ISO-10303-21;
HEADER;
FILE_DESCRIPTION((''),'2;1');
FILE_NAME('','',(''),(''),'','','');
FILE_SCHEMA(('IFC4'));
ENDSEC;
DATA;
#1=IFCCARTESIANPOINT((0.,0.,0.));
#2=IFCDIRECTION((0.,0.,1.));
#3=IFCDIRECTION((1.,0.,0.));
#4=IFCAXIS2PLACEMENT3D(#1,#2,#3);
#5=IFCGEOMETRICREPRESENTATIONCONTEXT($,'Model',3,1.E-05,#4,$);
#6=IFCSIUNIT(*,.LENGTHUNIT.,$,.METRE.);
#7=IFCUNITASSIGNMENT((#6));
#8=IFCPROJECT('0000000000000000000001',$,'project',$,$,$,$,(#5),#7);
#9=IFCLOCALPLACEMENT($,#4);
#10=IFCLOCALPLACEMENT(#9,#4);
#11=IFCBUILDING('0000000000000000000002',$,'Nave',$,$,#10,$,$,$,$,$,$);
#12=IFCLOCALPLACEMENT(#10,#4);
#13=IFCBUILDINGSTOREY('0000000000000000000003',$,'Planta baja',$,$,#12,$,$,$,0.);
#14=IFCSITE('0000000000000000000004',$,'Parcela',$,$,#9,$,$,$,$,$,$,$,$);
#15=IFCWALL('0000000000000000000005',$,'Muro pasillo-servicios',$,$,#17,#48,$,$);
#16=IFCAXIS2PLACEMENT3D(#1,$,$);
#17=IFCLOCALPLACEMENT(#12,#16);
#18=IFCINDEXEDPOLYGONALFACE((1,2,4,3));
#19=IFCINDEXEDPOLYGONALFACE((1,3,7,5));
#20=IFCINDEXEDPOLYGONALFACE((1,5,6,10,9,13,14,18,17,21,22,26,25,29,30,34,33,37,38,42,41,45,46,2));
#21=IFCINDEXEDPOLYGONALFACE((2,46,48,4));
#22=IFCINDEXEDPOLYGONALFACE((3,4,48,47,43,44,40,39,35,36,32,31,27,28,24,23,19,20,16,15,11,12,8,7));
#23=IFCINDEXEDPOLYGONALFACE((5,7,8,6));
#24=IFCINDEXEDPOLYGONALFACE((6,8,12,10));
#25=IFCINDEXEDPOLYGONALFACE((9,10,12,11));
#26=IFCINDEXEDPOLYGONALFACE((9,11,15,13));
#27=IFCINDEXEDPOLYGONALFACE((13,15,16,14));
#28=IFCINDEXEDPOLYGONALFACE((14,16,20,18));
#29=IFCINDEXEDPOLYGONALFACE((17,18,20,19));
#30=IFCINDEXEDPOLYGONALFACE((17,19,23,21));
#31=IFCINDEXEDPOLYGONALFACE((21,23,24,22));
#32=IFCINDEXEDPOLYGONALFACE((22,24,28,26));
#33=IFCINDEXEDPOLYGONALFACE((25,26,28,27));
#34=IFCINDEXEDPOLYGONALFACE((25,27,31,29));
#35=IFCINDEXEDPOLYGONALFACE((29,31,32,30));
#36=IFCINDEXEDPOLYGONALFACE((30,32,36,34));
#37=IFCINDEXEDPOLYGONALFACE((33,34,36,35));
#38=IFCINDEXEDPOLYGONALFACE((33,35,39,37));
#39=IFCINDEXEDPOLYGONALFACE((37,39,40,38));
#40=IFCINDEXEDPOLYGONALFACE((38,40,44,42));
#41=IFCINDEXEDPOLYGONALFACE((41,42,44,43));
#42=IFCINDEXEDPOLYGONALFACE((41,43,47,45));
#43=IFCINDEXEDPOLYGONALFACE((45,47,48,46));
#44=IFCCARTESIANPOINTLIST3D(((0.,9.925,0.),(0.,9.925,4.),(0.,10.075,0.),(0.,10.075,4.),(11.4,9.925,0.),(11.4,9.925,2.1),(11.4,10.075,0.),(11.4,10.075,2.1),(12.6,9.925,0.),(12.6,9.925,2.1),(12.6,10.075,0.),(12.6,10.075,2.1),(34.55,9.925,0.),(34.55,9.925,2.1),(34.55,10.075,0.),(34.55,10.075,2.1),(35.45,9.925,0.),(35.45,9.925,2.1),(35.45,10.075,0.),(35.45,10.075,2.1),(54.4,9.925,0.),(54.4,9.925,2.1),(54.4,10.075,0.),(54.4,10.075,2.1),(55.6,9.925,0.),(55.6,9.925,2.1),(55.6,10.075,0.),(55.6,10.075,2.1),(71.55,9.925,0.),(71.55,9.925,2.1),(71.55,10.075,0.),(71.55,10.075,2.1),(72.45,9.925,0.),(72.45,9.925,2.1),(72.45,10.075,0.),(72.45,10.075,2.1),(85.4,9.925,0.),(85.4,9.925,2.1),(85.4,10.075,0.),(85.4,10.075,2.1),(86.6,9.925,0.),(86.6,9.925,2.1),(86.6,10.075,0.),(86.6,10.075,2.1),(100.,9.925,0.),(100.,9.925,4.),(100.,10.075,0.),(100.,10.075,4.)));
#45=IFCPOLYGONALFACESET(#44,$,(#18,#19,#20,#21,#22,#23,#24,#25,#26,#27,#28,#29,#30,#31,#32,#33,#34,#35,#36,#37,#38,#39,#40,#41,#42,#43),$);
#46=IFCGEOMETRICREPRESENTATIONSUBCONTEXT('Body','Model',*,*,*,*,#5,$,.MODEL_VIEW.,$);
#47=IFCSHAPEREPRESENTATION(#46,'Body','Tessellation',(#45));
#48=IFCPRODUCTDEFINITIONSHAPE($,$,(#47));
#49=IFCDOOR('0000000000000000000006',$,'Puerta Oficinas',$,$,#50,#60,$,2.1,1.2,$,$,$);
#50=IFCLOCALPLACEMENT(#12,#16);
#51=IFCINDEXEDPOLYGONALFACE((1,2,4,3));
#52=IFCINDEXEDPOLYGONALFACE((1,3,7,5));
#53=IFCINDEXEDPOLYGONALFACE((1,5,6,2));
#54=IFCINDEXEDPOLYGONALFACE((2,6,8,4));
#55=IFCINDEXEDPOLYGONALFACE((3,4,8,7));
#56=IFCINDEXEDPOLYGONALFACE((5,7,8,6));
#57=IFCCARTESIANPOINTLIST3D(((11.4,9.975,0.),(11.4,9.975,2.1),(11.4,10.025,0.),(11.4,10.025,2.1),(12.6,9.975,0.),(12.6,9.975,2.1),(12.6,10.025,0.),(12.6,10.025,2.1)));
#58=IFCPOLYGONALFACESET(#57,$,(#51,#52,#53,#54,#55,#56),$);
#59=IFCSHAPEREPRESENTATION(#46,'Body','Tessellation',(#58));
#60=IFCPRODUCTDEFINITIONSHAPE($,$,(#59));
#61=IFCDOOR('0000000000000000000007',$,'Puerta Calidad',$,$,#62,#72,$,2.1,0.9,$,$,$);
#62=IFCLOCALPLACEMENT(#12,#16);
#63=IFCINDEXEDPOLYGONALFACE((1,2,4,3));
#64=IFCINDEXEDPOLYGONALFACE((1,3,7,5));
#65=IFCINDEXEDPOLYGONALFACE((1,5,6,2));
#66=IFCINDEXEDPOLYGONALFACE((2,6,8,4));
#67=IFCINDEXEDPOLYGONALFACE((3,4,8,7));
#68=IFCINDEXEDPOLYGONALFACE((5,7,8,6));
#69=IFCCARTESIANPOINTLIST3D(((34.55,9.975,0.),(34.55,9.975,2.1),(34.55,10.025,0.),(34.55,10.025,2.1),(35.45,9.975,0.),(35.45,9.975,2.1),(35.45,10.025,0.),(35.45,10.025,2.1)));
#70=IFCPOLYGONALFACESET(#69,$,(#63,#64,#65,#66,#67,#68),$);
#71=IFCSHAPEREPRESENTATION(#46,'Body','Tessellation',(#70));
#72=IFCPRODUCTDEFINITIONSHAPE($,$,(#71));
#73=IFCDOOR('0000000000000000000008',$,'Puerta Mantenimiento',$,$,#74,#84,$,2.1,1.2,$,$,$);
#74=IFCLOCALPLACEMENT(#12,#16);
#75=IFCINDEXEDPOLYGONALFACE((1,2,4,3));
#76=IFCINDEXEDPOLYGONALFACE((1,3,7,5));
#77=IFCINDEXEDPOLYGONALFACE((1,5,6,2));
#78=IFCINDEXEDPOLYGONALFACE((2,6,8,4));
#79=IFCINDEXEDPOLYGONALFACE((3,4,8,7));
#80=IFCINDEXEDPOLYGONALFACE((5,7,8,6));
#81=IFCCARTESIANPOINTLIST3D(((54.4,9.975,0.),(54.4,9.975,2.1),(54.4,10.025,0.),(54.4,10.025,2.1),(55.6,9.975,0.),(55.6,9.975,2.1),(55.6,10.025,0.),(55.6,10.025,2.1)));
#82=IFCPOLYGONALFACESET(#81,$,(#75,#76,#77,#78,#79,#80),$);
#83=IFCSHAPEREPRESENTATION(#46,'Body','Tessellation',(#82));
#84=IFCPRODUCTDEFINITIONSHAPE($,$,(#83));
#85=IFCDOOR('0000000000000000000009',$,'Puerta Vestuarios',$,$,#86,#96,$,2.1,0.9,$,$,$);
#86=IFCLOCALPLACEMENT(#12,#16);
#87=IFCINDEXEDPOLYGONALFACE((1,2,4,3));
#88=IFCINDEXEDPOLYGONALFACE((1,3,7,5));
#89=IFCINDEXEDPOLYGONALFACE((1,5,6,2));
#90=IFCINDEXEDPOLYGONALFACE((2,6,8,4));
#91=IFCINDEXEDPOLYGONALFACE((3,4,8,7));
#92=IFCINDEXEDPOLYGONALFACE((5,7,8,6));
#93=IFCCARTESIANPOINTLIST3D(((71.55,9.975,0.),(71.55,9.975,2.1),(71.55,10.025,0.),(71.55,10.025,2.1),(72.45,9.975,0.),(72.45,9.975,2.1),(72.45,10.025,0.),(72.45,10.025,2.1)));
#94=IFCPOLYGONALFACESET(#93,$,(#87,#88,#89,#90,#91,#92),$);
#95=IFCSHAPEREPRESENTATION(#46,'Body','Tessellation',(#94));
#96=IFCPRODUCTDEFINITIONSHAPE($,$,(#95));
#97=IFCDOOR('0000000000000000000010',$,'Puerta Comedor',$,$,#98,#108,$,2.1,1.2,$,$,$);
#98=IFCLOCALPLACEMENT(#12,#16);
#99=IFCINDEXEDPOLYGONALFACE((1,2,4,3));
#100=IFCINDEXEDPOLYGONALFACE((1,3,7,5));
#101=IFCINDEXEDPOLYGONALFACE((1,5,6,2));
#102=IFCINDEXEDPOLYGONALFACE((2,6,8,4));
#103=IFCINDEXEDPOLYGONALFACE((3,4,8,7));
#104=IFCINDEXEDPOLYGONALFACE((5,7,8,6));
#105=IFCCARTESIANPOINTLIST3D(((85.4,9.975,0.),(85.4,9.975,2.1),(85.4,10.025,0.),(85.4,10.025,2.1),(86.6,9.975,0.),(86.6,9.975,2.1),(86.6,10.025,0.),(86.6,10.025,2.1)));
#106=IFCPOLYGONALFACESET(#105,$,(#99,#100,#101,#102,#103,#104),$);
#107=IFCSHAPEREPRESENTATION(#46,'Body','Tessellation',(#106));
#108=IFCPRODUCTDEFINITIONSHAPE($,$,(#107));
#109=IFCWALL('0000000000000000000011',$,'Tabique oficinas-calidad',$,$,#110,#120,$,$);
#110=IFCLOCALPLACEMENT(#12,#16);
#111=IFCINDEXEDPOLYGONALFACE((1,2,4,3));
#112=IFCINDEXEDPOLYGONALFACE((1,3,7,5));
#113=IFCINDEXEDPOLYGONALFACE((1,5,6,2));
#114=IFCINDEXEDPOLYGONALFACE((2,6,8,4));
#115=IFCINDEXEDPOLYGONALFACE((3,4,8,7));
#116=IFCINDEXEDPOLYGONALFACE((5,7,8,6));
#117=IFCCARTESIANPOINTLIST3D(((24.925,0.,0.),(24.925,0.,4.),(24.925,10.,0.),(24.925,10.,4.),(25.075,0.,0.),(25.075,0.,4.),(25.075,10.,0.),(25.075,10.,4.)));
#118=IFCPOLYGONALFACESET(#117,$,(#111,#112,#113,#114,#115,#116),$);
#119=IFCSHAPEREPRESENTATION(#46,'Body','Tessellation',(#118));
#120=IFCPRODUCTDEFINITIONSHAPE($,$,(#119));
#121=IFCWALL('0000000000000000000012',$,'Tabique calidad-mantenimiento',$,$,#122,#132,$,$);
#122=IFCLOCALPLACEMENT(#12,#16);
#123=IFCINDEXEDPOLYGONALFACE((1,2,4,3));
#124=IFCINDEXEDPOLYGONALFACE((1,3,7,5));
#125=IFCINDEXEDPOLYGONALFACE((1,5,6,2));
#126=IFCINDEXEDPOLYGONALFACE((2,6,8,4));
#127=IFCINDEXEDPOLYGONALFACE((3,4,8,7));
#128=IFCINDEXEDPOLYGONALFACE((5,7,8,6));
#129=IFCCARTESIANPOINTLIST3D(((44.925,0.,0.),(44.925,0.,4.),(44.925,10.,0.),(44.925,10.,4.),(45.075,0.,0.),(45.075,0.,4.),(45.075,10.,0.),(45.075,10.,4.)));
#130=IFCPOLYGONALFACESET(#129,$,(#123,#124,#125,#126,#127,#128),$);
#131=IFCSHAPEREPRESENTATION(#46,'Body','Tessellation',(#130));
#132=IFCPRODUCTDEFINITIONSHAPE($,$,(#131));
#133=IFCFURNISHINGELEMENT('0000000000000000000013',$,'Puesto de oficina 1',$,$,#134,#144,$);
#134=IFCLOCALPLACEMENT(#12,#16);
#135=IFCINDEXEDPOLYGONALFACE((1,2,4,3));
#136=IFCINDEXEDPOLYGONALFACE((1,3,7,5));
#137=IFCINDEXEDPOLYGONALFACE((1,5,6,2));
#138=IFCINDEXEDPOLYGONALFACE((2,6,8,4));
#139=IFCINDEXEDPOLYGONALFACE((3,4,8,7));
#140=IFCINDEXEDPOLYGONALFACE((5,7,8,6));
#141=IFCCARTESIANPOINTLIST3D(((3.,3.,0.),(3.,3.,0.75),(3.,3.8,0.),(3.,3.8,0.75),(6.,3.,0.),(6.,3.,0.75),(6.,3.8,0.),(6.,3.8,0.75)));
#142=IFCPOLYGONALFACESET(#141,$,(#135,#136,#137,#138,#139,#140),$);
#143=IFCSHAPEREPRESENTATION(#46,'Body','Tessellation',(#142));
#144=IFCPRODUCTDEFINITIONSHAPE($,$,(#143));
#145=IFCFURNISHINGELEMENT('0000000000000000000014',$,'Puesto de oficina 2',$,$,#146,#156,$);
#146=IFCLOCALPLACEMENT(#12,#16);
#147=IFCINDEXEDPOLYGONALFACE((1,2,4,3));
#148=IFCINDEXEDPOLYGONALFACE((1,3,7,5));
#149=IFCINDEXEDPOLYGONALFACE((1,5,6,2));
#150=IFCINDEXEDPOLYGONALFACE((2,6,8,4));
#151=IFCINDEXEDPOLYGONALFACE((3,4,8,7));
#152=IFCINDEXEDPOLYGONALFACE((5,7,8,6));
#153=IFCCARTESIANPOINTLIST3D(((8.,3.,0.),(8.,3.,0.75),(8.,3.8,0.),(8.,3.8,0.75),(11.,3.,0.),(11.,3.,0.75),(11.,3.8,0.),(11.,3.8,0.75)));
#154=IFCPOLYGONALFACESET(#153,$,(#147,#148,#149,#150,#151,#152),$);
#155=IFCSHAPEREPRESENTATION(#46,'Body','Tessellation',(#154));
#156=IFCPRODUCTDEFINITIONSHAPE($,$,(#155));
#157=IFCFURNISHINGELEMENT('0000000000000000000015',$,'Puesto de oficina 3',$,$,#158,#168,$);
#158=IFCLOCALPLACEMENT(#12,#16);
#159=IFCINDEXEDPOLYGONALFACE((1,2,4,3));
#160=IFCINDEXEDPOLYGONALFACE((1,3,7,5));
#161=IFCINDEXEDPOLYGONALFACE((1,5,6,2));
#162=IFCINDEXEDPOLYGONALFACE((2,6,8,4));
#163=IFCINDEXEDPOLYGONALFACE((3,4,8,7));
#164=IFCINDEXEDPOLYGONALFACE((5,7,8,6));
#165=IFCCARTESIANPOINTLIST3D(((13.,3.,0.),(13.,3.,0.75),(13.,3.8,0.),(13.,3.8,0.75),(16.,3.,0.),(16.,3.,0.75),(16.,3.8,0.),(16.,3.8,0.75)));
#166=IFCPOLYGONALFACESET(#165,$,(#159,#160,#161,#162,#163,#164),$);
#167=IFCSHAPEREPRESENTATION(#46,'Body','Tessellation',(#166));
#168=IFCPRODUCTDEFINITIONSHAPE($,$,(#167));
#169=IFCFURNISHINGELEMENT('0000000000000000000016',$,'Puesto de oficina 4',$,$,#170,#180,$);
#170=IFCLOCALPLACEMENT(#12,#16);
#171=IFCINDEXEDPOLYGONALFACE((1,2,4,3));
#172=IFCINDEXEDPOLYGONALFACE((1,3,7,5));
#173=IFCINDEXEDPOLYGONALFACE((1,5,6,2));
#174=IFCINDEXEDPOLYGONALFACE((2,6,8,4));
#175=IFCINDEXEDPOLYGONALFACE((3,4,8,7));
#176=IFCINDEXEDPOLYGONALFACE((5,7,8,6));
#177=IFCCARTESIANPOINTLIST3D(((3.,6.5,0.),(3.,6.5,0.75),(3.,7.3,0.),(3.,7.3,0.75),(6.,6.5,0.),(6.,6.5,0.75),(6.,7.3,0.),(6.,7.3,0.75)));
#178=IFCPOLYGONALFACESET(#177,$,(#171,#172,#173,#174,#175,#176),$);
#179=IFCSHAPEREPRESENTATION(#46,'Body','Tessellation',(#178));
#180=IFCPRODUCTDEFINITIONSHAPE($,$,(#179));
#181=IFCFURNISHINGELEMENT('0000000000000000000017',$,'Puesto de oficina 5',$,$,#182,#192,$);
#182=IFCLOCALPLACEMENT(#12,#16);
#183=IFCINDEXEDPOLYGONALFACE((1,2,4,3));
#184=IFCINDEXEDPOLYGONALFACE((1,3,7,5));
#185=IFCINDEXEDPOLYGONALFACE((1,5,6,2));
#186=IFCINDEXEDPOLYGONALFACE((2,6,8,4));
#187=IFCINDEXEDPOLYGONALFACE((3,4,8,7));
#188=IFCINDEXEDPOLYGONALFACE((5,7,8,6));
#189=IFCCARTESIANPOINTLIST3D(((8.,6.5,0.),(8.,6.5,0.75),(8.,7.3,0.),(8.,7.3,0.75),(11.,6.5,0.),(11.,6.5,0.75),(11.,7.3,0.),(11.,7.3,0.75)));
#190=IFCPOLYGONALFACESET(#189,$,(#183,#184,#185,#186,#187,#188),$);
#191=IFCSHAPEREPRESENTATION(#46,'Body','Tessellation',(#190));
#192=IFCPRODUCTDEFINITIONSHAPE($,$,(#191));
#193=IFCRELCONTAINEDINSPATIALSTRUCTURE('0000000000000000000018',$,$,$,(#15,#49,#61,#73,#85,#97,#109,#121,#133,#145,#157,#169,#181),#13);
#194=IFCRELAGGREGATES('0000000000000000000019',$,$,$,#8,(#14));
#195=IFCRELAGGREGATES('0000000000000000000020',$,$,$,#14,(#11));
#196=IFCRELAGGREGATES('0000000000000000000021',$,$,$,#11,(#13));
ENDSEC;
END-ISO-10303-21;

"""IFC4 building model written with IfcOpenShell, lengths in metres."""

from ifc_helpers import new_model, si_unit, frame, origin_with_axes, place, context, subcontext, project, spatial, indexed_curve, outline, extrude, element, fill, save


model = new_model("IFC4")

# Units and contexts
model_context = context("Model", 3, precision=1e-05, world=origin_with_axes())
body_context = subcontext(model_context, "Body", "Model", "MODEL_VIEW")
ifc_project = project(units=[si_unit("LENGTHUNIT", "METRE")], contexts=[model_context])

# Site, building, storey
site_placement = place(None, origin_with_axes())
site = spatial("IfcSite", under=ifc_project, at=site_placement, Name="Parcela")
building_placement = place(site_placement, origin_with_axes())
building = spatial("IfcBuilding", under=site, at=building_placement, Name="Nave")
storey_placement = place(building_placement, origin_with_axes())
storey = spatial("IfcBuildingStorey", under=building, at=storey_placement, Name="Planta baja", Elevation=0.0)

# Wall, openings, doors
wall_1_placement = place(storey_placement, frame((0.0, 9.925, 0.0), z_axis=(0.0, 0.0, 1.0), x_axis=(1.0, 0.0, 0.0)))
wall_1 = element("IfcWall", 1, at=wall_1_placement, inside=storey, Name="Muro pasillo-servicios", context=body_context, shape_type="SweptSolid", body=[
    extrude(outline(indexed_curve([(0.0, 0.0), (0.0, 0.15), (100.0, 0.15), (100.0, 0.0), (0.0, 0.0)], self_intersect=False)), origin_with_axes(), (0.0, 0.0, 1.0), 4.0),
])
opening_1_placement = place(wall_1_placement, frame((11.4, -0.05, 0.0), z_axis=(0.0, 0.0, 1.0), x_axis=(1.0, 0.0, 0.0)))
opening_1 = element("IfcOpeningElement", 2, at=opening_1_placement, cuts=wall_1, context=body_context, shape_type="SweptSolid", body=[
    extrude(outline(indexed_curve([(0.0, 0.0), (0.0, 0.25), (1.2, 0.25), (1.2, 0.0), (0.0, 0.0)], self_intersect=False)), origin_with_axes(), (0.0, 0.0, 1.0), 2.1),
])
opening_2_placement = place(wall_1_placement, frame((34.55, -0.05, 0.0), z_axis=(0.0, 0.0, 1.0), x_axis=(1.0, 0.0, 0.0)))
opening_2 = element("IfcOpeningElement", 3, at=opening_2_placement, cuts=wall_1, context=body_context, shape_type="SweptSolid", body=[
    extrude(outline(indexed_curve([(0.0, 0.0), (0.0, 0.25), (0.9, 0.25), (0.9, 0.0), (0.0, 0.0)], self_intersect=False)), origin_with_axes(), (0.0, 0.0, 1.0), 2.1),
])
opening_3_placement = place(wall_1_placement, frame((54.4, -0.05, 0.0), z_axis=(0.0, 0.0, 1.0), x_axis=(1.0, 0.0, 0.0)))
opening_3 = element("IfcOpeningElement", 4, at=opening_3_placement, cuts=wall_1, context=body_context, shape_type="SweptSolid", body=[
    extrude(outline(indexed_curve([(0.0, 0.0), (0.0, 0.25), (1.2, 0.25), (1.2, 0.0), (0.0, 0.0)], self_intersect=False)), origin_with_axes(), (0.0, 0.0, 1.0), 2.1),
])
opening_4_placement = place(wall_1_placement, frame((71.55, -0.05, 0.0), z_axis=(0.0, 0.0, 1.0), x_axis=(1.0, 0.0, 0.0)))
opening_4 = element("IfcOpeningElement", 5, at=opening_4_placement, cuts=wall_1, context=body_context, shape_type="SweptSolid", body=[
    extrude(outline(indexed_curve([(0.0, 0.0), (0.0, 0.25), (0.9, 0.25), (0.9, 0.0), (0.0, 0.0)], self_intersect=False)), origin_with_axes(), (0.0, 0.0, 1.0), 2.1),
])
opening_5_placement = place(wall_1_placement, frame((85.4, -0.05, 0.0), z_axis=(0.0, 0.0, 1.0), x_axis=(1.0, 0.0, 0.0)))
opening_5 = element("IfcOpeningElement", 6, at=opening_5_placement, cuts=wall_1, context=body_context, shape_type="SweptSolid", body=[
    extrude(outline(indexed_curve([(0.0, 0.0), (0.0, 0.25), (1.2, 0.25), (1.2, 0.0), (0.0, 0.0)], self_intersect=False)), origin_with_axes(), (0.0, 0.0, 1.0), 2.1),
])
door_1_placement = place(opening_1_placement, frame((0.0, 0.1, 0.0), z_axis=(0.0, 0.0, 1.0), x_axis=(1.0, 0.0, 0.0)))
door_1 = element("IfcDoor", 7, at=door_1_placement, inside=storey, Name="Puerta Oficinas", OverallHeight=2.1, OverallWidth=1.2, context=body_context, shape_type="SweptSolid", body=[
    extrude(outline(indexed_curve([(0.0, 0.0), (0.0, 0.05), (1.2, 0.05), (1.2, 0.0), (0.0, 0.0)], self_intersect=False)), origin_with_axes(), (0.0, 0.0, 1.0), 2.1),
])
fill(opening_1, door_1)
door_2_placement = place(opening_2_placement, frame((0.0, 0.1, 0.0), z_axis=(0.0, 0.0, 1.0), x_axis=(1.0, 0.0, 0.0)))
door_2 = element("IfcDoor", 8, at=door_2_placement, inside=storey, Name="Puerta Calidad", OverallHeight=2.1, OverallWidth=0.9, context=body_context, shape_type="SweptSolid", body=[
    extrude(outline(indexed_curve([(0.0, 0.0), (0.0, 0.05), (0.9, 0.05), (0.9, 0.0), (0.0, 0.0)], self_intersect=False)), origin_with_axes(), (0.0, 0.0, 1.0), 2.1),
])
fill(opening_2, door_2)
door_3_placement = place(opening_3_placement, frame((0.0, 0.1, 0.0), z_axis=(0.0, 0.0, 1.0), x_axis=(1.0, 0.0, 0.0)))
door_3 = element("IfcDoor", 9, at=door_3_placement, inside=storey, Name="Puerta Mantenimiento", OverallHeight=2.1, OverallWidth=1.2, context=body_context, shape_type="SweptSolid", body=[
    extrude(outline(indexed_curve([(0.0, 0.0), (0.0, 0.05), (1.2, 0.05), (1.2, 0.0), (0.0, 0.0)], self_intersect=False)), origin_with_axes(), (0.0, 0.0, 1.0), 2.1),
])
fill(opening_3, door_3)
door_4_placement = place(opening_4_placement, frame((0.0, 0.1, 0.0), z_axis=(0.0, 0.0, 1.0), x_axis=(1.0, 0.0, 0.0)))
door_4 = element("IfcDoor", 10, at=door_4_placement, inside=storey, Name="Puerta Vestuarios", OverallHeight=2.1, OverallWidth=0.9, context=body_context, shape_type="SweptSolid", body=[
    extrude(outline(indexed_curve([(0.0, 0.0), (0.0, 0.05), (0.9, 0.05), (0.9, 0.0), (0.0, 0.0)], self_intersect=False)), origin_with_axes(), (0.0, 0.0, 1.0), 2.1),
])
fill(opening_4, door_4)
door_5_placement = place(opening_5_placement, frame((0.0, 0.1, 0.0), z_axis=(0.0, 0.0, 1.0), x_axis=(1.0, 0.0, 0.0)))
door_5 = element("IfcDoor", 11, at=door_5_placement, inside=storey, Name="Puerta Comedor", OverallHeight=2.1, OverallWidth=1.2, context=body_context, shape_type="SweptSolid", body=[
    extrude(outline(indexed_curve([(0.0, 0.0), (0.0, 0.05), (1.2, 0.05), (1.2, 0.0), (0.0, 0.0)], self_intersect=False)), origin_with_axes(), (0.0, 0.0, 1.0), 2.1),
])
fill(opening_5, door_5)

# Walls
for number, where, z_axis, x_axis, name in (
    (12, (25.075, 0.0, 0.0), (0.0, 0.0, 1.0), (0.0, 1.0, 0.0), "Tabique oficinas-calidad"),
    (13, (45.075, 0.0, 0.0), (0.0, 0.0, 1.0), (0.0, 1.0, 0.0), "Tabique calidad-mantenimiento"),
):
    element("IfcWall", number, at=place(storey_placement, frame(where, z_axis=z_axis, x_axis=x_axis)), inside=storey, Name=name, context=body_context, shape_type="SweptSolid", body=[
        extrude(outline(indexed_curve([(0.0, 0.0), (0.0, 0.15), (10.0, 0.15), (10.0, 0.0), (0.0, 0.0)], self_intersect=False)), origin_with_axes(), (0.0, 0.0, 1.0), 4.0),
    ])

# Furnishing elements
for number, where, z_axis, x_axis, name in (
    (14, (3.0, 3.0, 0.0), (0.0, 0.0, 1.0), (1.0, 0.0, 0.0), "Puesto de oficina 1"),
    (15, (8.0, 3.0, 0.0), (0.0, 0.0, 1.0), (1.0, 0.0, 0.0), "Puesto de oficina 2"),
    (16, (13.0, 3.0, 0.0), (0.0, 0.0, 1.0), (1.0, 0.0, 0.0), "Puesto de oficina 3"),
    (17, (3.0, 6.5, 0.0), (0.0, 0.0, 1.0), (1.0, 0.0, 0.0), "Puesto de oficina 4"),
    (18, (8.0, 6.5, 0.0), (0.0, 0.0, 1.0), (1.0, 0.0, 0.0), "Puesto de oficina 5"),
):
    element("IfcFurnishingElement", number, at=place(storey_placement, frame(where, z_axis=z_axis, x_axis=x_axis)), inside=storey, Name=name, context=body_context, shape_type="SweptSolid", body=[
        extrude(outline(indexed_curve([(0.0, 0.0), (0.0, 0.8), (3.0, 0.8), (3.0, 0.0), (0.0, 0.0)], self_intersect=False)), origin_with_axes(), (0.0, 0.0, 1.0), 0.75),
    ])

save(model, "model.ifc")
